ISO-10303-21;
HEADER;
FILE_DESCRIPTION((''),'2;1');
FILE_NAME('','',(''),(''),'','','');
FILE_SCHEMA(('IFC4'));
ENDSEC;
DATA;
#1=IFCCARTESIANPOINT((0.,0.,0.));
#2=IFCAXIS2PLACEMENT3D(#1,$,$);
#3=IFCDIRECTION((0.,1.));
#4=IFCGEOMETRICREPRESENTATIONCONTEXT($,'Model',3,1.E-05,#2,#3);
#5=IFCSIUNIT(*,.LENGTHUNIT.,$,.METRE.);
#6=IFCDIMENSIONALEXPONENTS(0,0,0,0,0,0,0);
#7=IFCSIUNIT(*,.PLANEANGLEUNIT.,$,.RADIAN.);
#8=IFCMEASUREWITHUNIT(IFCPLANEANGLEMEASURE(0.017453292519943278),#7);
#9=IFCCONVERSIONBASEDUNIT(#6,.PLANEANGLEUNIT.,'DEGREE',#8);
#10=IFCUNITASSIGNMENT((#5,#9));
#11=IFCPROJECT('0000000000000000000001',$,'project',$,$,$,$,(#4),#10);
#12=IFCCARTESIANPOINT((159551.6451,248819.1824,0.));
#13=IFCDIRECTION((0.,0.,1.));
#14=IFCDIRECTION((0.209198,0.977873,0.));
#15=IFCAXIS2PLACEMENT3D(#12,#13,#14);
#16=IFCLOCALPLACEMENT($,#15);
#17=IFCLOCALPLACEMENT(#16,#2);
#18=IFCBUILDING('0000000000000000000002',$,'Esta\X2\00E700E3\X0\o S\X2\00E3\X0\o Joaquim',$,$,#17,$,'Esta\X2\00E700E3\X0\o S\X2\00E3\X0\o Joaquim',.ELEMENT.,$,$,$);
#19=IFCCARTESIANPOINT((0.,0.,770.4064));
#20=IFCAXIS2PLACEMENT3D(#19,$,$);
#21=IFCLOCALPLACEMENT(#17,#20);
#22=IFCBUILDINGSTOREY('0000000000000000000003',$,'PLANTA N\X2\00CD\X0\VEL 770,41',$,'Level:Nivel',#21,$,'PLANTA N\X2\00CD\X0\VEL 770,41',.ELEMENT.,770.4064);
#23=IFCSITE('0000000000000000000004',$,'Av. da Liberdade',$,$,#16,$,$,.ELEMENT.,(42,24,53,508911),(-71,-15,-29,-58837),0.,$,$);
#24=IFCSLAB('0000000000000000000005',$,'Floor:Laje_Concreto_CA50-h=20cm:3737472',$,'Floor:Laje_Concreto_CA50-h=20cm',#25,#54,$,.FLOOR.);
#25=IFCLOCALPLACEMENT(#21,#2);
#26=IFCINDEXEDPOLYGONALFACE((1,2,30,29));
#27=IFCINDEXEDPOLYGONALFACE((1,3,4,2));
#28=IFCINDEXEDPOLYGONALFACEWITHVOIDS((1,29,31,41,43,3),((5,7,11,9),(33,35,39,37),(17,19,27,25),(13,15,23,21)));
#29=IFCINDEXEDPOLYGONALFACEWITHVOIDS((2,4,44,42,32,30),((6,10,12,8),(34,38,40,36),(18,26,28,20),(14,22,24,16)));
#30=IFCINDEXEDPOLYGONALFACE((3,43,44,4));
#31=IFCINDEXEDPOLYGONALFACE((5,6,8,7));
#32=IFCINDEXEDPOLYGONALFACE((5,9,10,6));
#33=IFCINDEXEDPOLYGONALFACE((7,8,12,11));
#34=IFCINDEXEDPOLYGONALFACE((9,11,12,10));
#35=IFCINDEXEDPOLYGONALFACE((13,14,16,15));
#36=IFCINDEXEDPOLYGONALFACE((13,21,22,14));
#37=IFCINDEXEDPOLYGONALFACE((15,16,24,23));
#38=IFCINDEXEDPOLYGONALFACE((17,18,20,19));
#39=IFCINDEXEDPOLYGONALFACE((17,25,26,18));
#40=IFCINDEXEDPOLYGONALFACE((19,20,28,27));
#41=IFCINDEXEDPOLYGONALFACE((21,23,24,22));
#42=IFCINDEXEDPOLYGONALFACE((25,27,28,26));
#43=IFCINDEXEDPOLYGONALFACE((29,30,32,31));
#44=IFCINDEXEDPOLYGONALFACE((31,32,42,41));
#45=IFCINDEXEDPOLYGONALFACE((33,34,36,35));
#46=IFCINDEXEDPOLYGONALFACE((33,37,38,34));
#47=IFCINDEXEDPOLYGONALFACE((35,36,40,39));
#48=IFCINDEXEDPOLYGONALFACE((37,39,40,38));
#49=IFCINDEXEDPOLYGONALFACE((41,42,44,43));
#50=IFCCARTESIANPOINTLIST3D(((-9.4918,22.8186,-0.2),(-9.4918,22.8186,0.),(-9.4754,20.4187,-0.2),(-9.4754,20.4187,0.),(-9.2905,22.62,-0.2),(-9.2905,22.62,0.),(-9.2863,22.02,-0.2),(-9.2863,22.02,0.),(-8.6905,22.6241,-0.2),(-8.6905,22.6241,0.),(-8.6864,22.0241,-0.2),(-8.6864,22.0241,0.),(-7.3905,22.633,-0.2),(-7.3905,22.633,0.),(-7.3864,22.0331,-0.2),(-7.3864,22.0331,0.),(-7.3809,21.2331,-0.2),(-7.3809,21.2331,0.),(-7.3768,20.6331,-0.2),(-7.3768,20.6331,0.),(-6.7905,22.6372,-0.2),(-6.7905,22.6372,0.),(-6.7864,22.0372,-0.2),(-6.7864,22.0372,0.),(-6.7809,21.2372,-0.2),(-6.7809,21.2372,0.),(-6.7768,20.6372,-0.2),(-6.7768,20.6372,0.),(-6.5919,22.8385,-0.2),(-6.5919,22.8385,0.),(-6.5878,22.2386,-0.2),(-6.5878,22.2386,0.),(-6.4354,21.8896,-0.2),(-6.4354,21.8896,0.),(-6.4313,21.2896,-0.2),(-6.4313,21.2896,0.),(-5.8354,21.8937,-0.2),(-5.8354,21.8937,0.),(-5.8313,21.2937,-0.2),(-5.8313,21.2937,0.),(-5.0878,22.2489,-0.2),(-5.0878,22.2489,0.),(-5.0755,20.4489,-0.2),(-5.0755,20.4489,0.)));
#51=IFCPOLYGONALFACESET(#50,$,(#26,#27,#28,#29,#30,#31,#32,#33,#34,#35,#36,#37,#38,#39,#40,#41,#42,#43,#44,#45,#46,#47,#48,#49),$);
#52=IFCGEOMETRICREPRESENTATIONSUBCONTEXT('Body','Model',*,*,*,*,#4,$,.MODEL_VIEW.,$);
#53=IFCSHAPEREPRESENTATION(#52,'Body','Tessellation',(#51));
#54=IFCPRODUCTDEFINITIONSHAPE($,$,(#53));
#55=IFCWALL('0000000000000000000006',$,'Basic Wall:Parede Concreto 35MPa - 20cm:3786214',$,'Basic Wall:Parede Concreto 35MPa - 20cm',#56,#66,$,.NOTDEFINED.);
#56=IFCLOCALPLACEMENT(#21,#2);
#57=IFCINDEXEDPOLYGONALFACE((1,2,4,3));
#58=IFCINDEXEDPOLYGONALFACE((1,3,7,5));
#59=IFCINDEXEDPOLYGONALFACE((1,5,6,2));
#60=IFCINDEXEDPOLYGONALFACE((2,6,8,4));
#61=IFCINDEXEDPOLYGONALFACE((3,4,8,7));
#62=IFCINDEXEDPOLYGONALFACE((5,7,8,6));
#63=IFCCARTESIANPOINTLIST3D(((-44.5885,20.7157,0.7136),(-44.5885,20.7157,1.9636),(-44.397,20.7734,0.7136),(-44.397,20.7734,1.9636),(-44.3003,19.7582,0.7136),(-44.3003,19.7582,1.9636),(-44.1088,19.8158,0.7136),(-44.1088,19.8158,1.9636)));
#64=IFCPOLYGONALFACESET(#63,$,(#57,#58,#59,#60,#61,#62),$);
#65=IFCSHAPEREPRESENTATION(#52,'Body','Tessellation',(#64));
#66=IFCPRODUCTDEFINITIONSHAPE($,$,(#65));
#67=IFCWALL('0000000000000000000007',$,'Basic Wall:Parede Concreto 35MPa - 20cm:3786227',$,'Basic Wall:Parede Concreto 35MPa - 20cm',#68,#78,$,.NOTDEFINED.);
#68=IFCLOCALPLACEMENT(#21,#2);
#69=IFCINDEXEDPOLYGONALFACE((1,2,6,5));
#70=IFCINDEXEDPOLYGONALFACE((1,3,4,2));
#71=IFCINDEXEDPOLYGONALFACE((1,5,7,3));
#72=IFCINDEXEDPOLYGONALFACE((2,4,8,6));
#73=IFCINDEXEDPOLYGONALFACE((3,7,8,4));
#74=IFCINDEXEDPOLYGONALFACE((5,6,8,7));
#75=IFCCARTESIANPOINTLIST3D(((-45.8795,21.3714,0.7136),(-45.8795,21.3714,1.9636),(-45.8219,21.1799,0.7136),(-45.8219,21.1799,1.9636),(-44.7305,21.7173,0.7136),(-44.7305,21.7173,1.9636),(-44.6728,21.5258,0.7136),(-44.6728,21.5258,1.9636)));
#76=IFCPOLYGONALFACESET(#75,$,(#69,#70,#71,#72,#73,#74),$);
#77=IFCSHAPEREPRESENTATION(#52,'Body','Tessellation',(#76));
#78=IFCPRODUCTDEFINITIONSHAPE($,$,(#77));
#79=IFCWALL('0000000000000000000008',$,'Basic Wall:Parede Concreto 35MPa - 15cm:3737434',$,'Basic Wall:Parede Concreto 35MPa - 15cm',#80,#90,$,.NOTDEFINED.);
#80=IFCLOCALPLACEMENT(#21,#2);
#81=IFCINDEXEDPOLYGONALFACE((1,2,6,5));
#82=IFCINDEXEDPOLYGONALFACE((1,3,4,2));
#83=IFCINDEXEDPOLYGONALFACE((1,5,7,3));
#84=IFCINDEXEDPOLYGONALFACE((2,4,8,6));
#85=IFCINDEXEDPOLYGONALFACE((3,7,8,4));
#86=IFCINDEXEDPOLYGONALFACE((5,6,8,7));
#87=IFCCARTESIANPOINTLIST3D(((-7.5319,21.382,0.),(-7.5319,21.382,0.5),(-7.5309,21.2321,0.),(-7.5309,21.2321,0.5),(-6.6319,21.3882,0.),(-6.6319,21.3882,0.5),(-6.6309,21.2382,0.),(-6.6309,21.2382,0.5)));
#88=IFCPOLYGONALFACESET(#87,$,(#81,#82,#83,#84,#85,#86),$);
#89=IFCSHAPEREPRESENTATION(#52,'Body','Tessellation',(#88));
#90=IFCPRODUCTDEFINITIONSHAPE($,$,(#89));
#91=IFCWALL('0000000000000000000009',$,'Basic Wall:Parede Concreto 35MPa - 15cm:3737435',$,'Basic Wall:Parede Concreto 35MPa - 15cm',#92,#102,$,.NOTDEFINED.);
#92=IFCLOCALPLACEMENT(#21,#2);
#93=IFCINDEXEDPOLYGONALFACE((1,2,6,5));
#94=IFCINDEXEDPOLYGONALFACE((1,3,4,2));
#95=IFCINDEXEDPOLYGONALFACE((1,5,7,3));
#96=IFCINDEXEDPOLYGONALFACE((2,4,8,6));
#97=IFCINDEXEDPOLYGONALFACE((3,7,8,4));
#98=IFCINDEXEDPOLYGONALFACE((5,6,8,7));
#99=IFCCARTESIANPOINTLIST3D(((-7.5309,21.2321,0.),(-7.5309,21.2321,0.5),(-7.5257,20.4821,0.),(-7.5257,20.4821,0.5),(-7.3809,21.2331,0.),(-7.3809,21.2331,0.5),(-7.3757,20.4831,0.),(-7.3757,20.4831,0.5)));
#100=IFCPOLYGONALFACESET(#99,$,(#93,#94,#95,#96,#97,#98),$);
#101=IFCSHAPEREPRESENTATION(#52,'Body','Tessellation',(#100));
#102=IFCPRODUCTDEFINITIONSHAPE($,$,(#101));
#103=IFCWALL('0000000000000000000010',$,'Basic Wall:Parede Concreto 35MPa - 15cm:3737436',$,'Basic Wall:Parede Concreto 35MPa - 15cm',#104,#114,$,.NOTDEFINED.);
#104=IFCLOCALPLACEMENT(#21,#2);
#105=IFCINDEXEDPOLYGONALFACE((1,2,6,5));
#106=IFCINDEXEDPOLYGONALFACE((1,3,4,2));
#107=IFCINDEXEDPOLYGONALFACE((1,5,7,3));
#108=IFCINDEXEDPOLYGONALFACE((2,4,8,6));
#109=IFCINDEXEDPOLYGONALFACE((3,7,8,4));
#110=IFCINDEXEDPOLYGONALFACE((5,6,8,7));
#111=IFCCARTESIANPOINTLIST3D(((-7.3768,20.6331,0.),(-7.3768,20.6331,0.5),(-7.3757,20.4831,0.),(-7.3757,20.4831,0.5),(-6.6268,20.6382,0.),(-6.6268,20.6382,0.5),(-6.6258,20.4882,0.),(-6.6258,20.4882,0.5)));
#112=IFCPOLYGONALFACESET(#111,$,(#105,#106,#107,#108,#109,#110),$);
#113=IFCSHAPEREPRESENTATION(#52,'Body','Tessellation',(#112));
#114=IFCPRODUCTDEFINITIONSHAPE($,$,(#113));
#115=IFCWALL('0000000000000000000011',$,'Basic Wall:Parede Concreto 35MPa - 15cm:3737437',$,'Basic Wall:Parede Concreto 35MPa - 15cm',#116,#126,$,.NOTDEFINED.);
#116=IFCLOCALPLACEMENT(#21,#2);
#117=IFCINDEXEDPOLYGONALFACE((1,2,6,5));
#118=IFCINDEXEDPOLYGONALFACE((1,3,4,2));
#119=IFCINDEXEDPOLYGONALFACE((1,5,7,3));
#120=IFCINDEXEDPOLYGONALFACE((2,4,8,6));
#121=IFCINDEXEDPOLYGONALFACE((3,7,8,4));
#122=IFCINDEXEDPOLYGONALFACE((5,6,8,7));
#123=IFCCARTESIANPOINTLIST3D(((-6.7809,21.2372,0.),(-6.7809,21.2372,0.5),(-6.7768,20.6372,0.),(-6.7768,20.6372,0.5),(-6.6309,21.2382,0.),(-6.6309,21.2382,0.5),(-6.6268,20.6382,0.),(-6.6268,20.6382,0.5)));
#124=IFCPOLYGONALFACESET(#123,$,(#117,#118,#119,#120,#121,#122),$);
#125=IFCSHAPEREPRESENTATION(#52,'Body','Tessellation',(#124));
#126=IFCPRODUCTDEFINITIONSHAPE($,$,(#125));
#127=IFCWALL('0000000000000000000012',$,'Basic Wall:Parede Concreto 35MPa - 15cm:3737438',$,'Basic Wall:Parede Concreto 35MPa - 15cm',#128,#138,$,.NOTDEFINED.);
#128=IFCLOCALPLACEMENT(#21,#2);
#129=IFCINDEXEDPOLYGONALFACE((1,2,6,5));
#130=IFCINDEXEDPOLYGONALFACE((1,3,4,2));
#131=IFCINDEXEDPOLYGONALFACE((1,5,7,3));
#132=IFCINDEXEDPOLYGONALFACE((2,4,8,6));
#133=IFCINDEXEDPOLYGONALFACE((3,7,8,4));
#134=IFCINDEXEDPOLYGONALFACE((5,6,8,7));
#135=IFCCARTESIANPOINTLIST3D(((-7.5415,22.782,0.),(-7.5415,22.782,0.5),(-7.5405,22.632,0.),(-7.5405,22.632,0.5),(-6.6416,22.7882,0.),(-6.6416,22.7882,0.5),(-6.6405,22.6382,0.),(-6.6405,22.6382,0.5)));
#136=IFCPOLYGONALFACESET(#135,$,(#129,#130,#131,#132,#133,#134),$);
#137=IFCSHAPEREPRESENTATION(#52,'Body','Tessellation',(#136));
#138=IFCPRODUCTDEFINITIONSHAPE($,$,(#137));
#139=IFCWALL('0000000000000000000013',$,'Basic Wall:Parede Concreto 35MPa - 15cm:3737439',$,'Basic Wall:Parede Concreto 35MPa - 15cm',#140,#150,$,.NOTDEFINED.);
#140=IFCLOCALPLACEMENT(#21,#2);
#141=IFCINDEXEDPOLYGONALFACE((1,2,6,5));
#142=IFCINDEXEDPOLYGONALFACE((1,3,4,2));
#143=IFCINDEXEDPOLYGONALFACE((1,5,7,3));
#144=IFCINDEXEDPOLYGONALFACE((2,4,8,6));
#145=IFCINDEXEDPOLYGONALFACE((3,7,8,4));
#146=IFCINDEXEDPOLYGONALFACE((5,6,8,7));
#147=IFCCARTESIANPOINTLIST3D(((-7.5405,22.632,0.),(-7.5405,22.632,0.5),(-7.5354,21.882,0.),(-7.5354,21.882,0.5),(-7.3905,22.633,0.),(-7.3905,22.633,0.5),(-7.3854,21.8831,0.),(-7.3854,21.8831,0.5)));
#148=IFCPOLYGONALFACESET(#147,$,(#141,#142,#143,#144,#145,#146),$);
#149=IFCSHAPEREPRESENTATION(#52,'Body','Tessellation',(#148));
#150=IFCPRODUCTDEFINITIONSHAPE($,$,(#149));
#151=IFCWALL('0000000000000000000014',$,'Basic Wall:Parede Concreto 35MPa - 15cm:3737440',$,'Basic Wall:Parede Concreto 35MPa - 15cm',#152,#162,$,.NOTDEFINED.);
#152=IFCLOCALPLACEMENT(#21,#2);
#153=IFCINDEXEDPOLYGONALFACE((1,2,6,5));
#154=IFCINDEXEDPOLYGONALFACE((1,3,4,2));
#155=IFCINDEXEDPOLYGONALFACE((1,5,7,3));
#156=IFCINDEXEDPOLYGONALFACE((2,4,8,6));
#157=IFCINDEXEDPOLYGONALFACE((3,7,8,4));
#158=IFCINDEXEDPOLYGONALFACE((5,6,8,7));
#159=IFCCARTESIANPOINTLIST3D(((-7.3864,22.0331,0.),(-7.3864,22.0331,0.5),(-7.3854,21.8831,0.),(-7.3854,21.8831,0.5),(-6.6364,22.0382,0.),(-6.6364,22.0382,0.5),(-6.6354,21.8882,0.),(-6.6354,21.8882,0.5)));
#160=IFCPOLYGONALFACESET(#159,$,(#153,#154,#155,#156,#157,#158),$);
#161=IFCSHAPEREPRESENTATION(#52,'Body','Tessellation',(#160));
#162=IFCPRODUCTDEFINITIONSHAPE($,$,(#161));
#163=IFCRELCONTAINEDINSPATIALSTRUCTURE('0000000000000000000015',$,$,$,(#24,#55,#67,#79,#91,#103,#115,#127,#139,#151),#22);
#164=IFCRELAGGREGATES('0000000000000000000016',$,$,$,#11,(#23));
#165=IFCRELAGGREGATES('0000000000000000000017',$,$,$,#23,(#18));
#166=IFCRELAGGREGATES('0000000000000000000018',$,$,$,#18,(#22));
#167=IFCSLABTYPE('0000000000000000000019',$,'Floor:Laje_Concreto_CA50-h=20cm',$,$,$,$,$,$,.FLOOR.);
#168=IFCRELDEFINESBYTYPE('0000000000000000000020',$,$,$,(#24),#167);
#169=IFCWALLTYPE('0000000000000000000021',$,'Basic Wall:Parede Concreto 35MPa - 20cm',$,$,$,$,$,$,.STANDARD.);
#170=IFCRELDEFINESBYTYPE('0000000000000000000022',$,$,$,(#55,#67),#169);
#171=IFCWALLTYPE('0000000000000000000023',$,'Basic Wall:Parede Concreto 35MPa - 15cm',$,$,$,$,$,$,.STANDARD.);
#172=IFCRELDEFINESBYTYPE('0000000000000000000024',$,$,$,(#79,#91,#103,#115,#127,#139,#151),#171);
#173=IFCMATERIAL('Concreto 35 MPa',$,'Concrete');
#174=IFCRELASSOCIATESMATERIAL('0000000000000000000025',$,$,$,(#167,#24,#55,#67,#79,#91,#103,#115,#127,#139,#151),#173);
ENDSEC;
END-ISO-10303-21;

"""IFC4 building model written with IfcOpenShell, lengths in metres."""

from ifc_helpers import new_model, entity, si_unit, converted_unit, direction, frame, origin, place, context, subcontext, project, spatial, indexed_curve, outline, extrude, material, type_object, element, save


model = new_model("IFC4")

# Units and contexts
model_context = context("Model", 3, precision=1e-05, world=origin(), true_north=direction((0.0, 1.0)))
body_context = subcontext(model_context, "Body", "Model", "MODEL_VIEW")
ifc_project = project(units=[si_unit("LENGTHUNIT", "METRE"), converted_unit("PLANEANGLEUNIT", "DEGREE", entity("IfcPlaneAngleMeasure", 0.017453292519943278), si_unit("PLANEANGLEUNIT", "RADIAN"), dimensions=[0, 0, 0, 0, 0, 0, 0])], contexts=[model_context])

# Site, building, storey
site_placement = place(None, frame((159551.6451, 248819.1824, 0.0), z_axis=(0.0, 0.0, 1.0), x_axis=(0.209198, 0.977873, 0.0)))
site = spatial("IfcSite", under=ifc_project, at=site_placement, Name="Av. da Liberdade", CompositionType="ELEMENT", RefLatitude=(42, 24, 53, 508911), RefLongitude=(-71, -15, -29, -58837), RefElevation=0.0)
building_placement = place(site_placement, origin())
building = spatial("IfcBuilding", under=site, at=building_placement, Name="Estação São Joaquim", LongName="Estação São Joaquim", CompositionType="ELEMENT")
storey_placement = place(building_placement, frame((0.0, 0.0, 770.4064)))
storey = spatial("IfcBuildingStorey", under=building, at=storey_placement, Name="PLANTA NÍVEL 770,41", ObjectType="Level:Nivel", LongName="PLANTA NÍVEL 770,41", CompositionType="ELEMENT", Elevation=770.4064)

# Slab, openings
ifc_material = material(Name="Concreto 35 MPa", Category="Concrete")
slab_type = type_object("IfcSlabType", Name="Floor:Laje_Concreto_CA50-h=20cm", PredefinedType="FLOOR", material=ifc_material)
slab_placement = place(storey_placement, origin())
slab = element("IfcSlab", 1, at=slab_placement, inside=storey, type_object=slab_type, material=ifc_material, Name="Floor:Laje_Concreto_CA50-h=20cm:3737472", ObjectType="Floor:Laje_Concreto_CA50-h=20cm", PredefinedType="FLOOR", context=body_context, shape_type="SweptSolid", body=[
    extrude(outline(indexed_curve([(-2.0, 0.55), (-2.0, -1.05), (-2.0, -1.25), (-0.3, -1.25), (2.4, -1.25), (2.4, -1.05), (2.4, 0.95), (2.4, 1.15), (-0.5, 1.15), (-0.5, 0.95), (-0.5, 0.55), (-1.8, 0.55), (-2.0, 0.55)], self_intersect=False), holes=[indexed_curve([(0.3, 0.95), (0.3, 0.35), (-0.3, 0.35), (-0.3, 0.95), (0.3, 0.95)], self_intersect=False), indexed_curve([(-0.65, 0.2), (-0.65, -0.4), (-1.25, -0.4), (-1.25, 0.2), (-0.65, 0.2)], self_intersect=False), indexed_curve([(0.3, -0.45), (0.3, -1.05), (-0.3, -1.05), (-0.3, -0.45), (0.3, -0.45)], self_intersect=False), indexed_curve([(2.2, 0.35), (1.6, 0.35), (1.6, 0.95), (2.2, 0.95), (2.2, 0.35)], self_intersect=False)]), frame((-7.084, 21.6851, -0.2), z_axis=(0.0, 0.0, -1.0), x_axis=(-0.999976, -0.006868, 0.0)), (0.0, 0.0, -1.0), 0.2),
])
opening_1_placement = place(slab_placement, origin())
element("IfcOpeningElement", 2, at=opening_1_placement, cuts=slab, PredefinedType="OPENING", context=body_context, shape_type="SweptSolid", body=[
    extrude(outline(indexed_curve([(-0.3, 0.3), (-0.3, -0.3), (0.3, -0.3), (0.3, 0.3), (-0.3, 0.3)], self_intersect=False)), frame((-7.0885, 22.3351, 0.0), z_axis=(0.0, 0.0, 1.0), x_axis=(0.999976, 0.006868, 0.0)), (0.0, 0.0, -1.0), 0.2),
])
opening_2_placement = place(slab_placement, origin())
element("IfcOpeningElement", 3, at=opening_2_placement, cuts=slab, PredefinedType="OPENING", context=body_context, shape_type="SweptSolid", body=[
    extrude(outline(indexed_curve([(-0.3, 0.3), (-0.3, -0.3), (0.3, -0.3), (0.3, 0.3), (-0.3, 0.3)], self_intersect=False)), frame((-6.1333, 21.5917, 0.0), z_axis=(0.0, 0.0, 1.0), x_axis=(0.999976, 0.006868, 0.0)), (0.0, 0.0, -1.0), 0.2),
])
opening_3_placement = place(slab_placement, origin())
element("IfcOpeningElement", 4, at=opening_3_placement, cuts=slab, PredefinedType="OPENING", context=body_context, shape_type="SweptSolid", body=[
    extrude(outline(indexed_curve([(-0.3, 0.3), (-0.3, -0.3), (0.3, -0.3), (0.3, 0.3), (-0.3, 0.3)], self_intersect=False)), frame((-7.0788, 20.9351, 0.0), z_axis=(0.0, 0.0, 1.0), x_axis=(0.999976, 0.006868, 0.0)), (0.0, 0.0, -1.0), 0.2),
])
opening_4_placement = place(slab_placement, origin())
element("IfcOpeningElement", 5, at=opening_4_placement, cuts=slab, PredefinedType="OPENING", context=body_context, shape_type="SweptSolid", body=[
    extrude(outline(indexed_curve([(-0.3, -0.3), (0.3, -0.3), (0.3, 0.3), (-0.3, 0.3), (-0.3, -0.3)], self_intersect=False)), frame((-8.9884, 22.3221, 0.0), z_axis=(0.0, 0.0, -1.0), x_axis=(-0.006868, 0.999976, 0.0)), (0.0, 0.0, 1.0), 0.2),
])

# Walls
wall_type_1 = type_object("IfcWallType", Name="Basic Wall:Parede Concreto 35MPa - 20cm", PredefinedType="STANDARD")
wall_1_placement = place(storey_placement, frame((-44.4928, 20.7445, 0.7136), z_axis=(0.0, 0.0, 1.0), x_axis=(0.288234, -0.95756, 0.0)))
element("IfcWall", 6, at=wall_1_placement, inside=storey, type_object=wall_type_1, material=ifc_material, Name="Basic Wall:Parede Concreto 35MPa - 20cm:3786214", ObjectType="Basic Wall:Parede Concreto 35MPa - 20cm", PredefinedType="NOTDEFINED", context=body_context, shape_type="SweptSolid", body=[
    extrude(outline(indexed_curve([(1.0, 0.1), (0.0, 0.1), (0.0, -0.1), (1.0, -0.1), (1.0, 0.1)], self_intersect=False)), origin(), (0.0, 0.0, 1.0), 1.25),
])
wall_2_placement = place(storey_placement, frame((-44.7017, 21.6216, 0.7136), z_axis=(0.0, 0.0, 1.0), x_axis=(-0.95756, -0.288234, 0.0)))
element("IfcWall", 7, at=wall_2_placement, inside=storey, type_object=wall_type_1, material=ifc_material, Name="Basic Wall:Parede Concreto 35MPa - 20cm:3786227", ObjectType="Basic Wall:Parede Concreto 35MPa - 20cm", PredefinedType="NOTDEFINED", context=body_context, shape_type="SweptSolid", body=[
    extrude(outline(indexed_curve([(1.2, 0.1), (0.0, 0.1), (0.0, -0.1), (1.2, -0.1), (1.2, 0.1)], self_intersect=False)), origin(), (0.0, 0.0, 1.0), 1.25),
])
wall_type_2 = type_object("IfcWallType", Name="Basic Wall:Parede Concreto 35MPa - 15cm", PredefinedType="STANDARD")
wall_3_placement = place(storey_placement, frame((-6.6314, 21.3132, 0.0), z_axis=(0.0, 0.0, 1.0), x_axis=(-0.999976, -0.006868, 0.0)))
element("IfcWall", 8, at=wall_3_placement, inside=storey, type_object=wall_type_2, material=ifc_material, Name="Basic Wall:Parede Concreto 35MPa - 15cm:3737434", ObjectType="Basic Wall:Parede Concreto 35MPa - 15cm", PredefinedType="NOTDEFINED", context=body_context, shape_type="SweptSolid", body=[
    extrude(outline(indexed_curve([(0.9, 0.075), (0.0, 0.075), (0.0, -0.075), (0.9, -0.075), (0.9, 0.075)], self_intersect=False)), origin(), (0.0, 0.0, 1.0), 0.5),
])
wall_4_placement = place(storey_placement, frame((-7.4559, 21.2326, 0.0), z_axis=(0.0, 0.0, 1.0), x_axis=(0.006868, -0.999976, 0.0)))
element("IfcWall", 9, at=wall_4_placement, inside=storey, type_object=wall_type_2, material=ifc_material, Name="Basic Wall:Parede Concreto 35MPa - 15cm:3737435", ObjectType="Basic Wall:Parede Concreto 35MPa - 15cm", PredefinedType="NOTDEFINED", context=body_context, shape_type="SweptSolid", body=[
    extrude(outline(indexed_curve([(0.75, 0.075), (0.0, 0.075), (0.0, -0.075), (0.75, -0.075), (0.75, 0.075)], self_intersect=False)), origin(), (0.0, 0.0, 1.0), 0.5),
])
wall_5_placement = place(storey_placement, frame((-7.3763, 20.5581, 0.0), z_axis=(0.0, 0.0, 1.0), x_axis=(0.999976, 0.006868, 0.0)))
element("IfcWall", 10, at=wall_5_placement, inside=storey, type_object=wall_type_2, material=ifc_material, Name="Basic Wall:Parede Concreto 35MPa - 15cm:3737436", ObjectType="Basic Wall:Parede Concreto 35MPa - 15cm", PredefinedType="NOTDEFINED", context=body_context, shape_type="SweptSolid", body=[
    extrude(outline(indexed_curve([(0.75, 0.075), (0.0, 0.075), (0.0, -0.075), (0.75, -0.075), (0.75, 0.075)], self_intersect=False)), origin(), (0.0, 0.0, 1.0), 0.5),
])
wall_6_placement = place(storey_placement, frame((-6.7018, 20.6377, 0.0), z_axis=(0.0, 0.0, 1.0), x_axis=(-0.006868, 0.999976, 0.0)))
element("IfcWall", 11, at=wall_6_placement, inside=storey, type_object=wall_type_2, material=ifc_material, Name="Basic Wall:Parede Concreto 35MPa - 15cm:3737437", ObjectType="Basic Wall:Parede Concreto 35MPa - 15cm", PredefinedType="NOTDEFINED", context=body_context, shape_type="SweptSolid", body=[
    extrude(outline(indexed_curve([(0.6, 0.075), (0.0, 0.075), (0.0, -0.075), (0.6, -0.075), (0.6, 0.075)], self_intersect=False)), origin(), (0.0, 0.0, 1.0), 0.5),
])
wall_7_placement = place(storey_placement, frame((-6.641, 22.7132, 0.0), z_axis=(0.0, 0.0, 1.0), x_axis=(-0.999976, -0.006868, 0.0)))
element("IfcWall", 12, at=wall_7_placement, inside=storey, type_object=wall_type_2, material=ifc_material, Name="Basic Wall:Parede Concreto 35MPa - 15cm:3737438", ObjectType="Basic Wall:Parede Concreto 35MPa - 15cm", PredefinedType="NOTDEFINED", context=body_context, shape_type="SweptSolid", body=[
    extrude(outline(indexed_curve([(0.9, 0.075), (0.0, 0.075), (0.0, -0.075), (0.9, -0.075), (0.9, 0.075)], self_intersect=False)), origin(), (0.0, 0.0, 1.0), 0.5),
])
wall_8_placement = place(storey_placement, frame((-7.4655, 22.6325, 0.0), z_axis=(0.0, 0.0, 1.0), x_axis=(0.006868, -0.999976, 0.0)))
element("IfcWall", 13, at=wall_8_placement, inside=storey, type_object=wall_type_2, material=ifc_material, Name="Basic Wall:Parede Concreto 35MPa - 15cm:3737439", ObjectType="Basic Wall:Parede Concreto 35MPa - 15cm", PredefinedType="NOTDEFINED", context=body_context, shape_type="SweptSolid", body=[
    extrude(outline(indexed_curve([(0.75, 0.075), (0.0, 0.075), (0.0, -0.075), (0.75, -0.075), (0.75, 0.075)], self_intersect=False)), origin(), (0.0, 0.0, 1.0), 0.5),
])
wall_9_placement = place(storey_placement, frame((-7.3859, 21.9581, 0.0), z_axis=(0.0, 0.0, 1.0), x_axis=(0.999976, 0.006868, 0.0)))
element("IfcWall", 14, at=wall_9_placement, inside=storey, type_object=wall_type_2, material=ifc_material, Name="Basic Wall:Parede Concreto 35MPa - 15cm:3737440", ObjectType="Basic Wall:Parede Concreto 35MPa - 15cm", PredefinedType="NOTDEFINED", context=body_context, shape_type="SweptSolid", body=[
    extrude(outline(indexed_curve([(0.75, 0.075), (0.0, 0.075), (0.0, -0.075), (0.75, -0.075), (0.75, 0.075)], self_intersect=False)), origin(), (0.0, 0.0, 1.0), 0.5),
])

save(model, "model.ifc")
